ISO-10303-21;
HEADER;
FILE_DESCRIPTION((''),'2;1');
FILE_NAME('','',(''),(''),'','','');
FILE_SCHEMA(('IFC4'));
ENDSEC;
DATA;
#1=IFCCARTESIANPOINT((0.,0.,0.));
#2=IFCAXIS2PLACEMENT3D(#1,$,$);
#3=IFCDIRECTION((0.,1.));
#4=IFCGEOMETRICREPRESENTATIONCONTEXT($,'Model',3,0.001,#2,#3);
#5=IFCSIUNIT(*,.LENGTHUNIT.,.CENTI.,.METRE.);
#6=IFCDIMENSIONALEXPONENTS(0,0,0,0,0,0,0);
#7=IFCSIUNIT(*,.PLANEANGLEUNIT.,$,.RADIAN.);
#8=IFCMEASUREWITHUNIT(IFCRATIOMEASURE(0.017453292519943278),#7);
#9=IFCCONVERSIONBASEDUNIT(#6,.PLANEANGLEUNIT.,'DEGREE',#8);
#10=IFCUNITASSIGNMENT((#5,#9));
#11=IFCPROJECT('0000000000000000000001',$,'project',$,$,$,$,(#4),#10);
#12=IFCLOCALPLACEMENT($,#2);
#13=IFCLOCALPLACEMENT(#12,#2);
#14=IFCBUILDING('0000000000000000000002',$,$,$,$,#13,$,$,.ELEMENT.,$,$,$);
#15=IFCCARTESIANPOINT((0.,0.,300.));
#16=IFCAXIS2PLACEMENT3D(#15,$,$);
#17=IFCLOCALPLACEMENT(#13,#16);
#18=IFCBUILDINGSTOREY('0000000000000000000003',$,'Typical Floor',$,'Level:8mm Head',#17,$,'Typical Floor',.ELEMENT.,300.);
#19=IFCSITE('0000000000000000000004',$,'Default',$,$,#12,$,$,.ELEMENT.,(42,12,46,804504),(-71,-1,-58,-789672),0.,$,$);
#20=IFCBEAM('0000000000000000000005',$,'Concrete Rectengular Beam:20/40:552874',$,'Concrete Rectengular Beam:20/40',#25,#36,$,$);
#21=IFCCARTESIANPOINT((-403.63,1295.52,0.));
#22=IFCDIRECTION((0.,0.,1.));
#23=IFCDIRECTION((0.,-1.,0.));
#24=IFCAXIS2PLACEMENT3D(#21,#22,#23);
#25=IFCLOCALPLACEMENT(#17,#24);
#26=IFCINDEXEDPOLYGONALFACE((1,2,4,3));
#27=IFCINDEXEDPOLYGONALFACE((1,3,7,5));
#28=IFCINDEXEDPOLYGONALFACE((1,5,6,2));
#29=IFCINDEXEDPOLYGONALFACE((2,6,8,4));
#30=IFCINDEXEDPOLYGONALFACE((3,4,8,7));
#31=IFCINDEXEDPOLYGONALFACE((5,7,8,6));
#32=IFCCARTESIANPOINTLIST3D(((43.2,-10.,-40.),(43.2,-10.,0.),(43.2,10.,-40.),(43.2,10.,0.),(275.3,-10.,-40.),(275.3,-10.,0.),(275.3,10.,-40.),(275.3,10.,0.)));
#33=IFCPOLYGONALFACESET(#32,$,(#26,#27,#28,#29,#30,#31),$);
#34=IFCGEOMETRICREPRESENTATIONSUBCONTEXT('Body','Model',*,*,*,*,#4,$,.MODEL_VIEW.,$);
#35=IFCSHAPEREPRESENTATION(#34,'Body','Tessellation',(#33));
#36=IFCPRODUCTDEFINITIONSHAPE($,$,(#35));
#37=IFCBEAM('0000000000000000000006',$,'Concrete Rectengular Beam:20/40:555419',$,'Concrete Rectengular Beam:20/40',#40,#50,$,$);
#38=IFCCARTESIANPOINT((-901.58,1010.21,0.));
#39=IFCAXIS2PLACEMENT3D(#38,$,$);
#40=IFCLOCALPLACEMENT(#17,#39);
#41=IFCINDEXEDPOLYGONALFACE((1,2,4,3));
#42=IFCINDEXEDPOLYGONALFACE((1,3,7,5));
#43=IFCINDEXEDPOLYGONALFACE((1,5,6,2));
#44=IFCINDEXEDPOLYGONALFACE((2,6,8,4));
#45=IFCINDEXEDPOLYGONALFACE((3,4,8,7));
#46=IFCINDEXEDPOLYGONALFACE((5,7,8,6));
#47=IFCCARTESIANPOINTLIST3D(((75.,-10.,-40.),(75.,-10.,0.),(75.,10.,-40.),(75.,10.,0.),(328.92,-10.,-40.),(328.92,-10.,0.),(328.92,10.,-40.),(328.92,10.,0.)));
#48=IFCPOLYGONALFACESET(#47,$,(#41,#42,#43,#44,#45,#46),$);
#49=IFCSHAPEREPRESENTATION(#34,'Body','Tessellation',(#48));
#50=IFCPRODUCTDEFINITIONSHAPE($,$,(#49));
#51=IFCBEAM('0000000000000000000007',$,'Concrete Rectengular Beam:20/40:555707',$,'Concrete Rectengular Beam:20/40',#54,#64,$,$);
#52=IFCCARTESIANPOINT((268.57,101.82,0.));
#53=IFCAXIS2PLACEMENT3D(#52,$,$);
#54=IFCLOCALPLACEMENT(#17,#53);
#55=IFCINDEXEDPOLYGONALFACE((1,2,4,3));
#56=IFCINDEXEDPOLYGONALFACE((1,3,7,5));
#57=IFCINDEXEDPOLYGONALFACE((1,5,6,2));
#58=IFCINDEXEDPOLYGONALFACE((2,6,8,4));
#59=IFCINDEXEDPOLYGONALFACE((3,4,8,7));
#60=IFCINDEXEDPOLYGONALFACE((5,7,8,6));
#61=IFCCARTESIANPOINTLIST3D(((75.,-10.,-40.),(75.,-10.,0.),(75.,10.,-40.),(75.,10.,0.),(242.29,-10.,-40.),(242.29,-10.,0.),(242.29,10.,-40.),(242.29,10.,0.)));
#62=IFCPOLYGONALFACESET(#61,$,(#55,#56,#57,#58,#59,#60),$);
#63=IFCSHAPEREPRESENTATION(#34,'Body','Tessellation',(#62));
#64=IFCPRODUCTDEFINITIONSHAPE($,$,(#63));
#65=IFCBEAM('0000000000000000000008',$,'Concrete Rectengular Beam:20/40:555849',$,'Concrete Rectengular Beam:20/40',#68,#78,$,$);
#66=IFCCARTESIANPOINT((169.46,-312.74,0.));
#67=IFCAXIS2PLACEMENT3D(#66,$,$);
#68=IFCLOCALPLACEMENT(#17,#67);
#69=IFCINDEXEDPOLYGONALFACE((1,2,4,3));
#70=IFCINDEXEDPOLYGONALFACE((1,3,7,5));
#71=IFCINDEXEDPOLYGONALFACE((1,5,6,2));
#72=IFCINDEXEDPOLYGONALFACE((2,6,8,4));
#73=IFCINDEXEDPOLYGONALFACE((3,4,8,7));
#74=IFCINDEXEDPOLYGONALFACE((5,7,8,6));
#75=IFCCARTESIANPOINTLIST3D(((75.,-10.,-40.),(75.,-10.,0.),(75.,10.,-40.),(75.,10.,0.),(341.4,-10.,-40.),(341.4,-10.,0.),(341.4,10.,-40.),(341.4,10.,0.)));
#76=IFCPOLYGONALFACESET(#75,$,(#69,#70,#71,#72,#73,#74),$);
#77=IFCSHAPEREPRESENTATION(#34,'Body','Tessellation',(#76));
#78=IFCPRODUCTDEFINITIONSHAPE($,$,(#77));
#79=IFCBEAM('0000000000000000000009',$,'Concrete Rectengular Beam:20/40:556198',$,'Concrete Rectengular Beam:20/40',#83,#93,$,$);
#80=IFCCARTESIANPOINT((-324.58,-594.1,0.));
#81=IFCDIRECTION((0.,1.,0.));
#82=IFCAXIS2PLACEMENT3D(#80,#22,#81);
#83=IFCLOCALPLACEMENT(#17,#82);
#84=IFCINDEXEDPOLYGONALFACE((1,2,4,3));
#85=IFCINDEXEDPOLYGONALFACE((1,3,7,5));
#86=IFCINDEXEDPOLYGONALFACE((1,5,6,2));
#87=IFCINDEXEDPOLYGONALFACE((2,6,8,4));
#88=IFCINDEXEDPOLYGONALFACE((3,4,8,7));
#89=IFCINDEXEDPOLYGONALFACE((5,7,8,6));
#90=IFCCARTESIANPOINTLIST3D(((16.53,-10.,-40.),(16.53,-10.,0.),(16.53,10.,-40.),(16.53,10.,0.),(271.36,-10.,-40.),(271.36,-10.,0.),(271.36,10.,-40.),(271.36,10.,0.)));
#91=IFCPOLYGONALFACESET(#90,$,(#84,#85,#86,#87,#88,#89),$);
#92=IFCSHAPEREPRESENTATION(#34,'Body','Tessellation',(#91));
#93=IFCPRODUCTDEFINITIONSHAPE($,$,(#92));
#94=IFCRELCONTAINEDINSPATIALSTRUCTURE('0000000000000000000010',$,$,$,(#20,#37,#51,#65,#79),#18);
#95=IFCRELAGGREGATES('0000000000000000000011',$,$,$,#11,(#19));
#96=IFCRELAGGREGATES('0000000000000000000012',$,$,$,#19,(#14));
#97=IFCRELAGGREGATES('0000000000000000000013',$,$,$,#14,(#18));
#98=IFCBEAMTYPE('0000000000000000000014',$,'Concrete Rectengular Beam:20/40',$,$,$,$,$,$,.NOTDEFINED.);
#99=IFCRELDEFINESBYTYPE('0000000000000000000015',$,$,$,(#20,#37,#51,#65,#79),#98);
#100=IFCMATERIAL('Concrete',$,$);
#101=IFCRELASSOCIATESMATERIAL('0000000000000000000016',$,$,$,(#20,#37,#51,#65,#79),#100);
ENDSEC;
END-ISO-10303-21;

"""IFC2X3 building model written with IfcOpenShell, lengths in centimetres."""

from ifc_helpers import new_model, entity, si_unit, converted_unit, direction, frame, frame_2d, origin, origin_2d_with_axis, place, context, subcontext, project, spatial, rectangle, extrude, material, type_object, element, save


model = new_model("IFC2X3")

# Units and contexts
model_context = context("Model", 3, precision=0.001, world=origin(), true_north=direction((0.0, 1.0)))
body_context = subcontext(model_context, "Body", "Model", "MODEL_VIEW")
ifc_project = project(units=[si_unit("LENGTHUNIT", "METRE", prefix="CENTI"), converted_unit("PLANEANGLEUNIT", "DEGREE", entity("IfcRatioMeasure", 0.017453292519943278), si_unit("PLANEANGLEUNIT", "RADIAN"), dimensions=[0, 0, 0, 0, 0, 0, 0])], contexts=[model_context])

# Site, building, storey
site_placement = place(None, origin())
site = spatial("IfcSite", under=ifc_project, at=site_placement, Name="Default", CompositionType="ELEMENT", RefLatitude=(42, 12, 46, 804504), RefLongitude=(-71, -1, -58, -789672), RefElevation=0.0)
building_placement = place(site_placement, origin())
building = spatial("IfcBuilding", under=site, at=building_placement, CompositionType="ELEMENT")
storey_placement = place(building_placement, frame((0.0, 0.0, 300.0)))
storey = spatial("IfcBuildingStorey", under=building, at=storey_placement, Name="Typical Floor", ObjectType="Level:8mm Head", LongName="Typical Floor", CompositionType="ELEMENT", Elevation=300.0)

# Beams
ifc_material = material(Name="Concrete")
beam_type = type_object("IfcBeamType", Name="Concrete Rectengular Beam:20/40", PredefinedType="NOTDEFINED")
beam_1_placement = place(storey_placement, frame((-403.63, 1295.52, 0.0), z_axis=(0.0, 0.0, 1.0), x_axis=(0.0, -1.0, 0.0)))
element("IfcBeam", 1, at=beam_1_placement, inside=storey, type_object=beam_type, material=ifc_material, Name="Concrete Rectengular Beam:20/40:552874", ObjectType="Concrete Rectengular Beam:20/40", context=body_context, shape_type="SweptSolid", body=[
    extrude(rectangle(XDim=40.0, YDim=20.0, at=origin_2d_with_axis()), frame((43.2, 0.0, -20.0), z_axis=(1.0, 0.0, 0.0), x_axis=(0.0, 0.0, -1.0)), (0.0, 0.0, 1.0), 232.1),
])
beam_2_placement = place(storey_placement, frame((-901.58, 1010.21, 0.0)))
element("IfcBeam", 2, at=beam_2_placement, inside=storey, type_object=beam_type, material=ifc_material, Name="Concrete Rectengular Beam:20/40:555419", ObjectType="Concrete Rectengular Beam:20/40", context=body_context, shape_type="SweptSolid", body=[
    extrude(rectangle(XDim=40.0, YDim=20.0, at=frame_2d((0.0, 0.0), x_axis=(1.0, 0.0))), frame((75.0, 0.0, -20.0), z_axis=(1.0, 0.0, 0.0), x_axis=(0.0, 0.0, -1.0)), (0.0, 0.0, 1.0), 253.92),
])
beam_3_placement = place(storey_placement, frame((268.57, 101.82, 0.0)))
element("IfcBeam", 3, at=beam_3_placement, inside=storey, type_object=beam_type, material=ifc_material, Name="Concrete Rectengular Beam:20/40:555707", ObjectType="Concrete Rectengular Beam:20/40", context=body_context, shape_type="SweptSolid", body=[
    extrude(rectangle(XDim=40.0, YDim=20.0, at=frame_2d((0.0, 0.0), x_axis=(1.0, 0.0))), frame((75.0, 0.0, -20.0), z_axis=(1.0, 0.0, 0.0), x_axis=(0.0, 0.0, -1.0)), (0.0, 0.0, 1.0), 167.29),
])
beam_4_placement = place(storey_placement, frame((169.46, -312.74, 0.0)))
element("IfcBeam", 4, at=beam_4_placement, inside=storey, type_object=beam_type, material=ifc_material, Name="Concrete Rectengular Beam:20/40:555849", ObjectType="Concrete Rectengular Beam:20/40", context=body_context, shape_type="SweptSolid", body=[
    extrude(rectangle(XDim=40.0, YDim=20.0, at=frame_2d((0.0, 0.0), x_axis=(1.0, 0.0))), frame((75.0, 0.0, -20.0), z_axis=(1.0, 0.0, 0.0), x_axis=(0.0, 0.0, -1.0)), (0.0, 0.0, 1.0), 266.4),
])
beam_5_placement = place(storey_placement, frame((-324.58, -594.1, 0.0), z_axis=(0.0, 0.0, 1.0), x_axis=(0.0, 1.0, 0.0)))
element("IfcBeam", 5, at=beam_5_placement, inside=storey, type_object=beam_type, material=ifc_material, Name="Concrete Rectengular Beam:20/40:556198", ObjectType="Concrete Rectengular Beam:20/40", context=body_context, shape_type="SweptSolid", body=[
    extrude(rectangle(XDim=40.0, YDim=20.0, at=frame_2d((0.0, 0.0), x_axis=(1.0, 0.0))), frame((16.53, 0.0, -20.0), z_axis=(1.0, 0.0, 0.0), x_axis=(0.0, 0.0, -1.0)), (0.0, 0.0, 1.0), 254.83),
])

save(model, "model.ifc")
